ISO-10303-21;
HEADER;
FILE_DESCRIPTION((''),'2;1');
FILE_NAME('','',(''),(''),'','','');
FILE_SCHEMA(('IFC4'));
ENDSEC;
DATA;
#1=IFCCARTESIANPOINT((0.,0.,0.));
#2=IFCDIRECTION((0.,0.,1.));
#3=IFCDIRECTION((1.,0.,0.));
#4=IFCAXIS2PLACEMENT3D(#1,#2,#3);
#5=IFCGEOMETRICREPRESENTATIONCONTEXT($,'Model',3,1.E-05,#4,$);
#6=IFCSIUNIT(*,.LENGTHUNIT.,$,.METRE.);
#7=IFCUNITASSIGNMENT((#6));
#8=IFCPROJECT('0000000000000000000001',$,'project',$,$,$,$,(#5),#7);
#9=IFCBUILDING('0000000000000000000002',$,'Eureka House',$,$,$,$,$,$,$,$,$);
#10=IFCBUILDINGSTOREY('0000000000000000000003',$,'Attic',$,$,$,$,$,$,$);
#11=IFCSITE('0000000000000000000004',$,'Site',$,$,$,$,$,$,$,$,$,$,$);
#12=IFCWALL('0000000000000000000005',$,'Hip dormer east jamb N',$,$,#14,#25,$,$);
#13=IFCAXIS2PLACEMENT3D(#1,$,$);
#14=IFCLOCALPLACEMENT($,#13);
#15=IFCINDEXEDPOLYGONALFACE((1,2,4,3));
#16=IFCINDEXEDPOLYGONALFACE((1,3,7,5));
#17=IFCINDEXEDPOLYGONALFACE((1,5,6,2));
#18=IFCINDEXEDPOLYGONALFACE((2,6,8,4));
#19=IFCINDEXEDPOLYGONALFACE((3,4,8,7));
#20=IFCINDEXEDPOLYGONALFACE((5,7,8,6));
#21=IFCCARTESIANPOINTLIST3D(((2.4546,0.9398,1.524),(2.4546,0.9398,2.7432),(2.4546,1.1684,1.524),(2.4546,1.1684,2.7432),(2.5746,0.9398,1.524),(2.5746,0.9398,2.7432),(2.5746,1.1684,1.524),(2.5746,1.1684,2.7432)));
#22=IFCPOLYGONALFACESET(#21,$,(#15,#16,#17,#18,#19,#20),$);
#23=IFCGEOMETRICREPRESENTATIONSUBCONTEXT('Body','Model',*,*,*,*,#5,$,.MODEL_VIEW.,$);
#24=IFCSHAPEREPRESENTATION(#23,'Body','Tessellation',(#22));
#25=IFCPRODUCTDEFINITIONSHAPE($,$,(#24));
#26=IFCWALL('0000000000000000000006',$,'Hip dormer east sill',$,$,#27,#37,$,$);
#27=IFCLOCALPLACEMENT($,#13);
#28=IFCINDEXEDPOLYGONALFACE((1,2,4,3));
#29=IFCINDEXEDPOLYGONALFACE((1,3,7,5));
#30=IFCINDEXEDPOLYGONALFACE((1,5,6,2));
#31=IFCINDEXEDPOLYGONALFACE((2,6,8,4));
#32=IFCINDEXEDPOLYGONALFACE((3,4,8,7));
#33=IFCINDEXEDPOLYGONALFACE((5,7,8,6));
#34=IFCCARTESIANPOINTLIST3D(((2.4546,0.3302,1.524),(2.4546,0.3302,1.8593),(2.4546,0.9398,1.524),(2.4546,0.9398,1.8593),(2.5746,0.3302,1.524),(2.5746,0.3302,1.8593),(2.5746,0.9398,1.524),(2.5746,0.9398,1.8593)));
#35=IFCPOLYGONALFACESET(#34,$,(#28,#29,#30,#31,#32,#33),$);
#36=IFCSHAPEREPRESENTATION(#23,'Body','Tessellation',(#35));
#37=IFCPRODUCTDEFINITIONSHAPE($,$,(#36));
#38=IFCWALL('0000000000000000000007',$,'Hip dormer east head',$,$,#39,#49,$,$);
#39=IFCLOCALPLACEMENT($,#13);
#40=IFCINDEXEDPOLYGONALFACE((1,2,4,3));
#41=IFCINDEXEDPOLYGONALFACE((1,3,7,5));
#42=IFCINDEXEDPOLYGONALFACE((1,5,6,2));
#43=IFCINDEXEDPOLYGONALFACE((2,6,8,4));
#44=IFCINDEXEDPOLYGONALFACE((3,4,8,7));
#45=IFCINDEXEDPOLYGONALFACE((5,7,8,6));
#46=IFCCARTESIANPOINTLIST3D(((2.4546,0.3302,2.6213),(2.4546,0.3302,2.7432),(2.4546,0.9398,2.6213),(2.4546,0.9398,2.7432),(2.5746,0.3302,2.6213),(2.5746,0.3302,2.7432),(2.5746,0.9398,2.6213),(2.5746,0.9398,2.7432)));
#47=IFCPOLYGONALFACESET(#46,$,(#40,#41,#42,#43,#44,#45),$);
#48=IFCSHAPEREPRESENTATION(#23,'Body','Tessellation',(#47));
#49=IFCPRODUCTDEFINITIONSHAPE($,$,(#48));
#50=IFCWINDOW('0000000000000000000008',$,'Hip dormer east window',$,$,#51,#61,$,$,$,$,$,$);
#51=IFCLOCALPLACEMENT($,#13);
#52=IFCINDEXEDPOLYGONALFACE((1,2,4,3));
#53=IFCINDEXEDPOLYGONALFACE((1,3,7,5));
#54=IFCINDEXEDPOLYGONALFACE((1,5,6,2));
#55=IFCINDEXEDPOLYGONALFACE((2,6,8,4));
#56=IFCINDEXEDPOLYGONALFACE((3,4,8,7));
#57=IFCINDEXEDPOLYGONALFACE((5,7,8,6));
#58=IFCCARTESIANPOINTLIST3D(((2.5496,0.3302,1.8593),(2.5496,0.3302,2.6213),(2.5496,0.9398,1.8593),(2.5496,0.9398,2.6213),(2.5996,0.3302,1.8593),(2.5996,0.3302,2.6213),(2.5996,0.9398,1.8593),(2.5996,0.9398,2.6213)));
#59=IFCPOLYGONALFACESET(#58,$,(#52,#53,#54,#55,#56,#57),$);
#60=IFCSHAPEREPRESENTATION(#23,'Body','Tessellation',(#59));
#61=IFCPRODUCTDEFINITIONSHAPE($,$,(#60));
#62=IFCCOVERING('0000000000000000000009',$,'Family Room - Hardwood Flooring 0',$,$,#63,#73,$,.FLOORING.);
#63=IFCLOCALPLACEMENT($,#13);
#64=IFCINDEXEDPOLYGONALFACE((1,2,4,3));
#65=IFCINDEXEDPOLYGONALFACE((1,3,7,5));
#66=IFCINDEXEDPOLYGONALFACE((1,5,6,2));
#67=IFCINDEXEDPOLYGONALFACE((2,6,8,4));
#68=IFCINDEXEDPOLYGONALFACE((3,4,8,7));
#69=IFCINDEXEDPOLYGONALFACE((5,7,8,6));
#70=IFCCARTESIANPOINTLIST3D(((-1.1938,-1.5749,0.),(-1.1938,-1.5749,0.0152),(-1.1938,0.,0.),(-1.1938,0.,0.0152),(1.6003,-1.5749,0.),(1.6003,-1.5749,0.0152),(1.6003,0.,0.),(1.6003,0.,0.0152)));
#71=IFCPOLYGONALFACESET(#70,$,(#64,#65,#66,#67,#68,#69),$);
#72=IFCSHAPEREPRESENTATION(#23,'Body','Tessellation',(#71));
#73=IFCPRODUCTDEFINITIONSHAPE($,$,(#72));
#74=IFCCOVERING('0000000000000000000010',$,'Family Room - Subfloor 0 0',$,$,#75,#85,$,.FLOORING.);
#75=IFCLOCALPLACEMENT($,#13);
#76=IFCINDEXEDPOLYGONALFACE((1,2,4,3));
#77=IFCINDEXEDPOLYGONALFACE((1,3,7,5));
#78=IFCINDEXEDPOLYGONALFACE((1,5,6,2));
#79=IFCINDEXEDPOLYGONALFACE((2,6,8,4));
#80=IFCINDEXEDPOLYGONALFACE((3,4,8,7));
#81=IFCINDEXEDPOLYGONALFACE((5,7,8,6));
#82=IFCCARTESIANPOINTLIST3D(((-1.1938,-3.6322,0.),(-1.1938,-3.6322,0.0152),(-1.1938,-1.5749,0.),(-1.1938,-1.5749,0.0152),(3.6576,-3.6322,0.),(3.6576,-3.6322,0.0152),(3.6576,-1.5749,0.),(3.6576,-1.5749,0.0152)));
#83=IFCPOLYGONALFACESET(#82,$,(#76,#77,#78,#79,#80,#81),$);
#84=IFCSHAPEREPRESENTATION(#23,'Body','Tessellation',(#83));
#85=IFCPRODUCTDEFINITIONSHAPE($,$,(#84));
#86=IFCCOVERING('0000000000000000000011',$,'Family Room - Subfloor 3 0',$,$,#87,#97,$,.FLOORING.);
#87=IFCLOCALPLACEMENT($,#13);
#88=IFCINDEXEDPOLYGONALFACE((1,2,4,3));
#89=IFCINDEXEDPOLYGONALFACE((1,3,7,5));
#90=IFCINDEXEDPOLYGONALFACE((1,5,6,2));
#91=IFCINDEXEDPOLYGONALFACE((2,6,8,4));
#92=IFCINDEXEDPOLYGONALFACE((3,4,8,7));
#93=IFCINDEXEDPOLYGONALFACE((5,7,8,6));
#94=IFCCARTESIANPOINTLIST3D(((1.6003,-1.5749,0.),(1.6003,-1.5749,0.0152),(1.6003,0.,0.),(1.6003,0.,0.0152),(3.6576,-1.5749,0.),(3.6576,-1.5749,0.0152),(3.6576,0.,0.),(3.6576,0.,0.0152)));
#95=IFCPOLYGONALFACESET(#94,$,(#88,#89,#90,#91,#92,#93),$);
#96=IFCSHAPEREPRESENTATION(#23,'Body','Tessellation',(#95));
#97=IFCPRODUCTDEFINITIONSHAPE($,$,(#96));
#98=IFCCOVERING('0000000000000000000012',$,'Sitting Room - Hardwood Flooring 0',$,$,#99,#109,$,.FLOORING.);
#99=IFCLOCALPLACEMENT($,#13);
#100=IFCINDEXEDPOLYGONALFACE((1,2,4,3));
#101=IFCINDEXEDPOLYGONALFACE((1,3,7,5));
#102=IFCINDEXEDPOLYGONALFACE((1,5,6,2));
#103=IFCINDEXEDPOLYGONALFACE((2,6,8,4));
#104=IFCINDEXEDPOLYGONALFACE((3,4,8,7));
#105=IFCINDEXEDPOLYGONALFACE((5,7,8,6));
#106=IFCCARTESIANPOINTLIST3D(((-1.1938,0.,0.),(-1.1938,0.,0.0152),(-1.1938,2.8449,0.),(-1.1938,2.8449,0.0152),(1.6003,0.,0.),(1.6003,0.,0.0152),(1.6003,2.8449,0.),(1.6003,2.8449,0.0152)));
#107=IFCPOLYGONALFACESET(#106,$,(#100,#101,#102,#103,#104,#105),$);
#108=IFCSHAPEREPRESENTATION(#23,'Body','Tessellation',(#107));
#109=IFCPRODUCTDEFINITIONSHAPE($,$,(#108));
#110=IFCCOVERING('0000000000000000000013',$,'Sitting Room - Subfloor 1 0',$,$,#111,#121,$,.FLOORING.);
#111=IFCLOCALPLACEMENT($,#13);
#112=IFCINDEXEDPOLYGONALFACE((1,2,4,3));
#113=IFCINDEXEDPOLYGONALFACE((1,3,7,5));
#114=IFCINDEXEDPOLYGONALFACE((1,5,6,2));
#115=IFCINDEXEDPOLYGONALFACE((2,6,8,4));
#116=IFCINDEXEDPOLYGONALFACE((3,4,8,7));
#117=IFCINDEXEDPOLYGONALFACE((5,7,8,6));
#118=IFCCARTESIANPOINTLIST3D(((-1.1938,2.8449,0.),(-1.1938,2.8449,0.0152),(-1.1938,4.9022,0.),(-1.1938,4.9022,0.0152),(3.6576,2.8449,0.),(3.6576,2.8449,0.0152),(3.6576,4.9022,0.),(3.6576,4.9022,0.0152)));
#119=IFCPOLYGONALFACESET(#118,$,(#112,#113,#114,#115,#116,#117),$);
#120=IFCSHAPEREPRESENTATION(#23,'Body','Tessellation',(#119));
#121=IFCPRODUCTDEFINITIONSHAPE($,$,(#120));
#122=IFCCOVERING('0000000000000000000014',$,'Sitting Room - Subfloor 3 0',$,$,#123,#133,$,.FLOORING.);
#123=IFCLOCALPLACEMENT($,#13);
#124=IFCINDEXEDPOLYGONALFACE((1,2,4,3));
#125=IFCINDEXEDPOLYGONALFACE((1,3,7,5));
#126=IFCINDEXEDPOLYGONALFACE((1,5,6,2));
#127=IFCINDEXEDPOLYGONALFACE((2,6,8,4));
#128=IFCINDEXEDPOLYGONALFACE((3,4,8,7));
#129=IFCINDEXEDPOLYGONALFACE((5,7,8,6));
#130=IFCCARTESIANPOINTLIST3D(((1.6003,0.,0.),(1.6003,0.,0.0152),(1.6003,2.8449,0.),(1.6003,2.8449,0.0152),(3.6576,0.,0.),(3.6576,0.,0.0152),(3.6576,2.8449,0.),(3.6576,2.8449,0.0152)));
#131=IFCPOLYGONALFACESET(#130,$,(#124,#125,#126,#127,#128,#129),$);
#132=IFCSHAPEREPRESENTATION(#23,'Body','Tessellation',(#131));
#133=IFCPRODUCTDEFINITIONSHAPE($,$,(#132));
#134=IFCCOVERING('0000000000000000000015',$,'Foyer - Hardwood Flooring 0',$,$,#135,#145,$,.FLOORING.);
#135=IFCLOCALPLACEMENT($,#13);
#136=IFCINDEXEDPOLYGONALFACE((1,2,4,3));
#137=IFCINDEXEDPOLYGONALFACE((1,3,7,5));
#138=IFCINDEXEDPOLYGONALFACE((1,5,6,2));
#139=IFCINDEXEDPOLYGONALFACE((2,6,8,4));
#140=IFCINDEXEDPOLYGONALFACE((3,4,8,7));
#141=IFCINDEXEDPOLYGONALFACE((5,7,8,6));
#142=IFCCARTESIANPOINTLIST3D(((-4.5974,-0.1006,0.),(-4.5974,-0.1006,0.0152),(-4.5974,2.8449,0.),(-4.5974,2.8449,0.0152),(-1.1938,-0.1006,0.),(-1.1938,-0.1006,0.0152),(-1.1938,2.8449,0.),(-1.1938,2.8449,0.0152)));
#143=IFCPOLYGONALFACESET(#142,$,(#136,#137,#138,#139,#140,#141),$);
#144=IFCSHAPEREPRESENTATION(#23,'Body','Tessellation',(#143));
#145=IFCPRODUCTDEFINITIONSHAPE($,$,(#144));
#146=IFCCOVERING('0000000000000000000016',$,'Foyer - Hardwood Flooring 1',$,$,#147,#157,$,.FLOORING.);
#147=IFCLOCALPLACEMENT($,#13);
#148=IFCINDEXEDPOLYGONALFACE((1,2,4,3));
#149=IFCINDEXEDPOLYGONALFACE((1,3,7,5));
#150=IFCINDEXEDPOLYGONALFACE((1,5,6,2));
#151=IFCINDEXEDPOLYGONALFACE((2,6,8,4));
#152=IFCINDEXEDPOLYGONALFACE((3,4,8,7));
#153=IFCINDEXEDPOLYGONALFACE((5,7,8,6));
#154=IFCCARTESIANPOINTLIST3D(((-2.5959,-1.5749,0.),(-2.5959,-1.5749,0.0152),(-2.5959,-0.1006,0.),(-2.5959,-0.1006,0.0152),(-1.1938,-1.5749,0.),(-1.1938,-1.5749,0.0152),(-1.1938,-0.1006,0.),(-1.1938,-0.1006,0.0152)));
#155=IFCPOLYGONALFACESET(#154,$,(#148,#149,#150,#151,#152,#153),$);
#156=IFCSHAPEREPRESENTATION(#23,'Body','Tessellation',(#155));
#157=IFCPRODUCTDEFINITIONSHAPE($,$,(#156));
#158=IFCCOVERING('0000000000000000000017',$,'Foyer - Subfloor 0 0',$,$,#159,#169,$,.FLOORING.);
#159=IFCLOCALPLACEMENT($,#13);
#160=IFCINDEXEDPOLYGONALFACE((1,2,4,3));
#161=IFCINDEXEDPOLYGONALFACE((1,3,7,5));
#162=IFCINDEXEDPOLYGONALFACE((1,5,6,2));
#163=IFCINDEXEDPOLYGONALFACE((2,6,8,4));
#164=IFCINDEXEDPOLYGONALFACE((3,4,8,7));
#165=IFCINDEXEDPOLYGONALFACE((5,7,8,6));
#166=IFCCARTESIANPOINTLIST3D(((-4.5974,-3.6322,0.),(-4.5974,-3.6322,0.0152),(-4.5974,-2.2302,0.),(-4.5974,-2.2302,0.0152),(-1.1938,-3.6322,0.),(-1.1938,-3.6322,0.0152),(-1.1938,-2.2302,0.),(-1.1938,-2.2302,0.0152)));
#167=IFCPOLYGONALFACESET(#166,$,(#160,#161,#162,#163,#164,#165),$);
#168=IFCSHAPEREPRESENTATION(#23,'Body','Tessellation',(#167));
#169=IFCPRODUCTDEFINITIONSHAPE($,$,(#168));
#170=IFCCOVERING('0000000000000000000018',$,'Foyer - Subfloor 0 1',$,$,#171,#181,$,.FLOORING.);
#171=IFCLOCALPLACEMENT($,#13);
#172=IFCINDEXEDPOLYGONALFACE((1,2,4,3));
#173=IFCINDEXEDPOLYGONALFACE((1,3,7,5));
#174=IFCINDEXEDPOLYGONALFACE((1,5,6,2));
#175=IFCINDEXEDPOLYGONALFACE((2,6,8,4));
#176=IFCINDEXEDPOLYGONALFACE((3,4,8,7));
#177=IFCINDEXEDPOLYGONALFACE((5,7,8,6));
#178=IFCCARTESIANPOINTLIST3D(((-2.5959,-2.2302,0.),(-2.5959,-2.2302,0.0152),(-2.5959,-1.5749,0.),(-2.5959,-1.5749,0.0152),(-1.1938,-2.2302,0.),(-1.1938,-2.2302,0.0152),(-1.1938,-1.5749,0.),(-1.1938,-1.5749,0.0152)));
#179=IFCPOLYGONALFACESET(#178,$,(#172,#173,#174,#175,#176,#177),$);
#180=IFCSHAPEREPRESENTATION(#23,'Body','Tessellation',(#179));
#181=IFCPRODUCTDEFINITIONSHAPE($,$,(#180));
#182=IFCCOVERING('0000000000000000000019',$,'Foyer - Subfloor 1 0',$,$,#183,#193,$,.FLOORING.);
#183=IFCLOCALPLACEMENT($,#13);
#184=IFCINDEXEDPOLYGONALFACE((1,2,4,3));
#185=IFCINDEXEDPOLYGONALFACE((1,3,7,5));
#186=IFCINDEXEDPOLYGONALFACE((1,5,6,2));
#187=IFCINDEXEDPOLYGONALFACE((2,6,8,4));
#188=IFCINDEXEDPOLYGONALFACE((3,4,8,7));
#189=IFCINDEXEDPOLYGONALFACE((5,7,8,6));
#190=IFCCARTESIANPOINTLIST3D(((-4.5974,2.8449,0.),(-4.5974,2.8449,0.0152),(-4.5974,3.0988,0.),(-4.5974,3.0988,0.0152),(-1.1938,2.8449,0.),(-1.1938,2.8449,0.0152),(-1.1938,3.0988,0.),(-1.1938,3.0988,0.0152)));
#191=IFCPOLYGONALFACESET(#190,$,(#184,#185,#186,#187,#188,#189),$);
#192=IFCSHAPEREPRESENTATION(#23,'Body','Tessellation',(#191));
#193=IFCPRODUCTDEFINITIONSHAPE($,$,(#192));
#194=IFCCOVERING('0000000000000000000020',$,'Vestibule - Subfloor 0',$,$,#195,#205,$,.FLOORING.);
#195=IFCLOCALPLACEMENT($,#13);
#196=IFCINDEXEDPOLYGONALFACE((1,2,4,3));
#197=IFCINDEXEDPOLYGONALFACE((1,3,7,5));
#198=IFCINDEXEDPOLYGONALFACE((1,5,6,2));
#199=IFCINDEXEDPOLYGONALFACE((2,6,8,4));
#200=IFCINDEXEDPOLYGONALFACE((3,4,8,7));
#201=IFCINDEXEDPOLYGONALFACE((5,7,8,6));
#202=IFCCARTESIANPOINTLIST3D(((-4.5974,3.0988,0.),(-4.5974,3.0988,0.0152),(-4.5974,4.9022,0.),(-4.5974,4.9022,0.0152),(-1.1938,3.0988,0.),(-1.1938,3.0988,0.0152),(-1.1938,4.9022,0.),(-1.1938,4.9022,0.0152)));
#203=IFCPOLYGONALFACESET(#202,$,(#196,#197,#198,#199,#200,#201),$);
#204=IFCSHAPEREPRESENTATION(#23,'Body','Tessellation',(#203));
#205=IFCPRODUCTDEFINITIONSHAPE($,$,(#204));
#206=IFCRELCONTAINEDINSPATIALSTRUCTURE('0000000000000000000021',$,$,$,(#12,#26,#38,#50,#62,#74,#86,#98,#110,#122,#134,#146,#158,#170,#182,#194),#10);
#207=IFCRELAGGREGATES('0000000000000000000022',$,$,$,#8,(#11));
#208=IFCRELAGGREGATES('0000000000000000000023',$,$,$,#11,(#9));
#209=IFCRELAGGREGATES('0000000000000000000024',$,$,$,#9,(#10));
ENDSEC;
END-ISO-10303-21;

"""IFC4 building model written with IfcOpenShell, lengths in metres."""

from ifc_helpers import new_model, si_unit, frame, origin, origin_with_axes, origin_2d, place, context, subcontext, project, spatial, rectangle, extrude, element, save


model = new_model("IFC4")

# Units and contexts
model_context = context("Model", 3, precision=1e-05, world=origin_with_axes())
body_context = subcontext(model_context, "Body", "Model", "MODEL_VIEW")
ifc_project = project(units=[si_unit("LENGTHUNIT", "METRE")], contexts=[model_context])

# Site, building, storey
site = spatial("IfcSite", under=ifc_project, Name="Site")
building = spatial("IfcBuilding", under=site, Name="Eureka House")
storey = spatial("IfcBuildingStorey", under=building, Name="Attic")

# Walls
wall_1_placement = place(None, frame((2.5146, 1.0541, 1.524), z_axis=(0.0, 0.0, 1.0), x_axis=(1.0, 0.0, 0.0)))
element("IfcWall", 1, at=wall_1_placement, inside=storey, Name="Hip dormer east jamb N", context=body_context, shape_type="SweptSolid", body=[
    extrude(rectangle(XDim=0.12, YDim=0.2286, at=origin_2d()), origin(), (0.0, 0.0, 1.0), 1.2192),
])
wall_2_placement = place(None, frame((2.5146, 0.635, 1.524), z_axis=(0.0, 0.0, 1.0), x_axis=(1.0, 0.0, 0.0)))
element("IfcWall", 2, at=wall_2_placement, inside=storey, Name="Hip dormer east sill", context=body_context, shape_type="SweptSolid", body=[
    extrude(rectangle(XDim=0.12, YDim=0.6096, at=origin_2d()), origin(), (0.0, 0.0, 1.0), 0.3353),
])
wall_3_placement = place(None, frame((2.5146, 0.635, 2.6213), z_axis=(0.0, 0.0, 1.0), x_axis=(1.0, 0.0, 0.0)))
element("IfcWall", 3, at=wall_3_placement, inside=storey, Name="Hip dormer east head", context=body_context, shape_type="SweptSolid", body=[
    extrude(rectangle(XDim=0.12, YDim=0.6096, at=origin_2d()), origin(), (0.0, 0.0, 1.0), 0.1219),
])

# Window
window_1_placement = place(None, frame((2.5746, 0.635, 1.8593), z_axis=(0.0, 0.0, 1.0), x_axis=(1.0, 0.0, 0.0)))
element("IfcWindow", 4, at=window_1_placement, inside=storey, Name="Hip dormer east window", context=body_context, shape_type="SweptSolid", body=[
    extrude(rectangle(XDim=0.05, YDim=0.6096, at=origin_2d()), origin(), (0.0, 0.0, 1.0), 0.762),
])

# Coverings
covering_1_placement = place(None, frame((0.2032, -0.7875, 0.0), z_axis=(0.0, 0.0, 1.0), x_axis=(1.0, 0.0, 0.0)))
element("IfcCovering", 5, at=covering_1_placement, inside=storey, Name="Family Room - Hardwood Flooring 0", PredefinedType="FLOORING", context=body_context, shape_type="SweptSolid", body=[
    extrude(rectangle(XDim=2.7941, YDim=1.5749, at=origin_2d()), origin(), (0.0, 0.0, 1.0), 0.0152),
])
covering_2_placement = place(None, frame((1.2319, -2.6036, 0.0), z_axis=(0.0, 0.0, 1.0), x_axis=(1.0, 0.0, 0.0)))
element("IfcCovering", 6, at=covering_2_placement, inside=storey, Name="Family Room - Subfloor 0 0", PredefinedType="FLOORING", context=body_context, shape_type="SweptSolid", body=[
    extrude(rectangle(XDim=4.8514, YDim=2.0573, at=origin_2d()), origin(), (0.0, 0.0, 1.0), 0.0152),
])
covering_3_placement = place(None, frame((2.629, -0.7875, 0.0), z_axis=(0.0, 0.0, 1.0), x_axis=(1.0, 0.0, 0.0)))
element("IfcCovering", 7, at=covering_3_placement, inside=storey, Name="Family Room - Subfloor 3 0", PredefinedType="FLOORING", context=body_context, shape_type="SweptSolid", body=[
    extrude(rectangle(XDim=2.0573, YDim=1.5749, at=origin_2d()), origin(), (0.0, 0.0, 1.0), 0.0152),
])
covering_4_placement = place(None, frame((0.2032, 1.4224, 0.0), z_axis=(0.0, 0.0, 1.0), x_axis=(1.0, 0.0, 0.0)))
element("IfcCovering", 8, at=covering_4_placement, inside=storey, Name="Sitting Room - Hardwood Flooring 0", PredefinedType="FLOORING", context=body_context, shape_type="SweptSolid", body=[
    extrude(rectangle(XDim=2.7941, YDim=2.8449, at=origin_2d()), origin(), (0.0, 0.0, 1.0), 0.0152),
])
covering_5_placement = place(None, frame((1.2319, 3.8735, 0.0), z_axis=(0.0, 0.0, 1.0), x_axis=(1.0, 0.0, 0.0)))
element("IfcCovering", 9, at=covering_5_placement, inside=storey, Name="Sitting Room - Subfloor 1 0", PredefinedType="FLOORING", context=body_context, shape_type="SweptSolid", body=[
    extrude(rectangle(XDim=4.8514, YDim=2.0573, at=origin_2d()), origin(), (0.0, 0.0, 1.0), 0.0152),
])
covering_6_placement = place(None, frame((2.629, 1.4224, 0.0), z_axis=(0.0, 0.0, 1.0), x_axis=(1.0, 0.0, 0.0)))
element("IfcCovering", 10, at=covering_6_placement, inside=storey, Name="Sitting Room - Subfloor 3 0", PredefinedType="FLOORING", context=body_context, shape_type="SweptSolid", body=[
    extrude(rectangle(XDim=2.0573, YDim=2.8449, at=origin_2d()), origin(), (0.0, 0.0, 1.0), 0.0152),
])
covering_7_placement = place(None, frame((-2.8956, 1.3722, 0.0), z_axis=(0.0, 0.0, 1.0), x_axis=(1.0, 0.0, 0.0)))
element("IfcCovering", 11, at=covering_7_placement, inside=storey, Name="Foyer - Hardwood Flooring 0", PredefinedType="FLOORING", context=body_context, shape_type="SweptSolid", body=[
    extrude(rectangle(XDim=3.4036, YDim=2.9455, at=origin_2d()), origin(), (0.0, 0.0, 1.0), 0.0152),
])
covering_8_placement = place(None, frame((-1.8949, -0.8377, 0.0), z_axis=(0.0, 0.0, 1.0), x_axis=(1.0, 0.0, 0.0)))
element("IfcCovering", 12, at=covering_8_placement, inside=storey, Name="Foyer - Hardwood Flooring 1", PredefinedType="FLOORING", context=body_context, shape_type="SweptSolid", body=[
    extrude(rectangle(XDim=1.4021, YDim=1.4743, at=origin_2d()), origin(), (0.0, 0.0, 1.0), 0.0152),
])
covering_9_placement = place(None, frame((-2.8956, -2.9312, 0.0), z_axis=(0.0, 0.0, 1.0), x_axis=(1.0, 0.0, 0.0)))
element("IfcCovering", 13, at=covering_9_placement, inside=storey, Name="Foyer - Subfloor 0 0", PredefinedType="FLOORING", context=body_context, shape_type="SweptSolid", body=[
    extrude(rectangle(XDim=3.4036, YDim=1.402, at=origin_2d()), origin(), (0.0, 0.0, 1.0), 0.0152),
])
covering_10_placement = place(None, frame((-1.8949, -1.9026, 0.0), z_axis=(0.0, 0.0, 1.0), x_axis=(1.0, 0.0, 0.0)))
element("IfcCovering", 14, at=covering_10_placement, inside=storey, Name="Foyer - Subfloor 0 1", PredefinedType="FLOORING", context=body_context, shape_type="SweptSolid", body=[
    extrude(rectangle(XDim=1.4021, YDim=0.6553, at=origin_2d()), origin(), (0.0, 0.0, 1.0), 0.0152),
])
covering_11_placement = place(None, frame((-2.8956, 2.9719, 0.0), z_axis=(0.0, 0.0, 1.0), x_axis=(1.0, 0.0, 0.0)))
element("IfcCovering", 15, at=covering_11_placement, inside=storey, Name="Foyer - Subfloor 1 0", PredefinedType="FLOORING", context=body_context, shape_type="SweptSolid", body=[
    extrude(rectangle(XDim=3.4036, YDim=0.2539, at=origin_2d()), origin(), (0.0, 0.0, 1.0), 0.0152),
])
covering_12_placement = place(None, frame((-2.8956, 4.0005, 0.0), z_axis=(0.0, 0.0, 1.0), x_axis=(1.0, 0.0, 0.0)))
element("IfcCovering", 16, at=covering_12_placement, inside=storey, Name="Vestibule - Subfloor 0", PredefinedType="FLOORING", context=body_context, shape_type="SweptSolid", body=[
    extrude(rectangle(XDim=3.4036, YDim=1.8034, at=origin_2d()), origin(), (0.0, 0.0, 1.0), 0.0152),
])

save(model, "model.ifc")
